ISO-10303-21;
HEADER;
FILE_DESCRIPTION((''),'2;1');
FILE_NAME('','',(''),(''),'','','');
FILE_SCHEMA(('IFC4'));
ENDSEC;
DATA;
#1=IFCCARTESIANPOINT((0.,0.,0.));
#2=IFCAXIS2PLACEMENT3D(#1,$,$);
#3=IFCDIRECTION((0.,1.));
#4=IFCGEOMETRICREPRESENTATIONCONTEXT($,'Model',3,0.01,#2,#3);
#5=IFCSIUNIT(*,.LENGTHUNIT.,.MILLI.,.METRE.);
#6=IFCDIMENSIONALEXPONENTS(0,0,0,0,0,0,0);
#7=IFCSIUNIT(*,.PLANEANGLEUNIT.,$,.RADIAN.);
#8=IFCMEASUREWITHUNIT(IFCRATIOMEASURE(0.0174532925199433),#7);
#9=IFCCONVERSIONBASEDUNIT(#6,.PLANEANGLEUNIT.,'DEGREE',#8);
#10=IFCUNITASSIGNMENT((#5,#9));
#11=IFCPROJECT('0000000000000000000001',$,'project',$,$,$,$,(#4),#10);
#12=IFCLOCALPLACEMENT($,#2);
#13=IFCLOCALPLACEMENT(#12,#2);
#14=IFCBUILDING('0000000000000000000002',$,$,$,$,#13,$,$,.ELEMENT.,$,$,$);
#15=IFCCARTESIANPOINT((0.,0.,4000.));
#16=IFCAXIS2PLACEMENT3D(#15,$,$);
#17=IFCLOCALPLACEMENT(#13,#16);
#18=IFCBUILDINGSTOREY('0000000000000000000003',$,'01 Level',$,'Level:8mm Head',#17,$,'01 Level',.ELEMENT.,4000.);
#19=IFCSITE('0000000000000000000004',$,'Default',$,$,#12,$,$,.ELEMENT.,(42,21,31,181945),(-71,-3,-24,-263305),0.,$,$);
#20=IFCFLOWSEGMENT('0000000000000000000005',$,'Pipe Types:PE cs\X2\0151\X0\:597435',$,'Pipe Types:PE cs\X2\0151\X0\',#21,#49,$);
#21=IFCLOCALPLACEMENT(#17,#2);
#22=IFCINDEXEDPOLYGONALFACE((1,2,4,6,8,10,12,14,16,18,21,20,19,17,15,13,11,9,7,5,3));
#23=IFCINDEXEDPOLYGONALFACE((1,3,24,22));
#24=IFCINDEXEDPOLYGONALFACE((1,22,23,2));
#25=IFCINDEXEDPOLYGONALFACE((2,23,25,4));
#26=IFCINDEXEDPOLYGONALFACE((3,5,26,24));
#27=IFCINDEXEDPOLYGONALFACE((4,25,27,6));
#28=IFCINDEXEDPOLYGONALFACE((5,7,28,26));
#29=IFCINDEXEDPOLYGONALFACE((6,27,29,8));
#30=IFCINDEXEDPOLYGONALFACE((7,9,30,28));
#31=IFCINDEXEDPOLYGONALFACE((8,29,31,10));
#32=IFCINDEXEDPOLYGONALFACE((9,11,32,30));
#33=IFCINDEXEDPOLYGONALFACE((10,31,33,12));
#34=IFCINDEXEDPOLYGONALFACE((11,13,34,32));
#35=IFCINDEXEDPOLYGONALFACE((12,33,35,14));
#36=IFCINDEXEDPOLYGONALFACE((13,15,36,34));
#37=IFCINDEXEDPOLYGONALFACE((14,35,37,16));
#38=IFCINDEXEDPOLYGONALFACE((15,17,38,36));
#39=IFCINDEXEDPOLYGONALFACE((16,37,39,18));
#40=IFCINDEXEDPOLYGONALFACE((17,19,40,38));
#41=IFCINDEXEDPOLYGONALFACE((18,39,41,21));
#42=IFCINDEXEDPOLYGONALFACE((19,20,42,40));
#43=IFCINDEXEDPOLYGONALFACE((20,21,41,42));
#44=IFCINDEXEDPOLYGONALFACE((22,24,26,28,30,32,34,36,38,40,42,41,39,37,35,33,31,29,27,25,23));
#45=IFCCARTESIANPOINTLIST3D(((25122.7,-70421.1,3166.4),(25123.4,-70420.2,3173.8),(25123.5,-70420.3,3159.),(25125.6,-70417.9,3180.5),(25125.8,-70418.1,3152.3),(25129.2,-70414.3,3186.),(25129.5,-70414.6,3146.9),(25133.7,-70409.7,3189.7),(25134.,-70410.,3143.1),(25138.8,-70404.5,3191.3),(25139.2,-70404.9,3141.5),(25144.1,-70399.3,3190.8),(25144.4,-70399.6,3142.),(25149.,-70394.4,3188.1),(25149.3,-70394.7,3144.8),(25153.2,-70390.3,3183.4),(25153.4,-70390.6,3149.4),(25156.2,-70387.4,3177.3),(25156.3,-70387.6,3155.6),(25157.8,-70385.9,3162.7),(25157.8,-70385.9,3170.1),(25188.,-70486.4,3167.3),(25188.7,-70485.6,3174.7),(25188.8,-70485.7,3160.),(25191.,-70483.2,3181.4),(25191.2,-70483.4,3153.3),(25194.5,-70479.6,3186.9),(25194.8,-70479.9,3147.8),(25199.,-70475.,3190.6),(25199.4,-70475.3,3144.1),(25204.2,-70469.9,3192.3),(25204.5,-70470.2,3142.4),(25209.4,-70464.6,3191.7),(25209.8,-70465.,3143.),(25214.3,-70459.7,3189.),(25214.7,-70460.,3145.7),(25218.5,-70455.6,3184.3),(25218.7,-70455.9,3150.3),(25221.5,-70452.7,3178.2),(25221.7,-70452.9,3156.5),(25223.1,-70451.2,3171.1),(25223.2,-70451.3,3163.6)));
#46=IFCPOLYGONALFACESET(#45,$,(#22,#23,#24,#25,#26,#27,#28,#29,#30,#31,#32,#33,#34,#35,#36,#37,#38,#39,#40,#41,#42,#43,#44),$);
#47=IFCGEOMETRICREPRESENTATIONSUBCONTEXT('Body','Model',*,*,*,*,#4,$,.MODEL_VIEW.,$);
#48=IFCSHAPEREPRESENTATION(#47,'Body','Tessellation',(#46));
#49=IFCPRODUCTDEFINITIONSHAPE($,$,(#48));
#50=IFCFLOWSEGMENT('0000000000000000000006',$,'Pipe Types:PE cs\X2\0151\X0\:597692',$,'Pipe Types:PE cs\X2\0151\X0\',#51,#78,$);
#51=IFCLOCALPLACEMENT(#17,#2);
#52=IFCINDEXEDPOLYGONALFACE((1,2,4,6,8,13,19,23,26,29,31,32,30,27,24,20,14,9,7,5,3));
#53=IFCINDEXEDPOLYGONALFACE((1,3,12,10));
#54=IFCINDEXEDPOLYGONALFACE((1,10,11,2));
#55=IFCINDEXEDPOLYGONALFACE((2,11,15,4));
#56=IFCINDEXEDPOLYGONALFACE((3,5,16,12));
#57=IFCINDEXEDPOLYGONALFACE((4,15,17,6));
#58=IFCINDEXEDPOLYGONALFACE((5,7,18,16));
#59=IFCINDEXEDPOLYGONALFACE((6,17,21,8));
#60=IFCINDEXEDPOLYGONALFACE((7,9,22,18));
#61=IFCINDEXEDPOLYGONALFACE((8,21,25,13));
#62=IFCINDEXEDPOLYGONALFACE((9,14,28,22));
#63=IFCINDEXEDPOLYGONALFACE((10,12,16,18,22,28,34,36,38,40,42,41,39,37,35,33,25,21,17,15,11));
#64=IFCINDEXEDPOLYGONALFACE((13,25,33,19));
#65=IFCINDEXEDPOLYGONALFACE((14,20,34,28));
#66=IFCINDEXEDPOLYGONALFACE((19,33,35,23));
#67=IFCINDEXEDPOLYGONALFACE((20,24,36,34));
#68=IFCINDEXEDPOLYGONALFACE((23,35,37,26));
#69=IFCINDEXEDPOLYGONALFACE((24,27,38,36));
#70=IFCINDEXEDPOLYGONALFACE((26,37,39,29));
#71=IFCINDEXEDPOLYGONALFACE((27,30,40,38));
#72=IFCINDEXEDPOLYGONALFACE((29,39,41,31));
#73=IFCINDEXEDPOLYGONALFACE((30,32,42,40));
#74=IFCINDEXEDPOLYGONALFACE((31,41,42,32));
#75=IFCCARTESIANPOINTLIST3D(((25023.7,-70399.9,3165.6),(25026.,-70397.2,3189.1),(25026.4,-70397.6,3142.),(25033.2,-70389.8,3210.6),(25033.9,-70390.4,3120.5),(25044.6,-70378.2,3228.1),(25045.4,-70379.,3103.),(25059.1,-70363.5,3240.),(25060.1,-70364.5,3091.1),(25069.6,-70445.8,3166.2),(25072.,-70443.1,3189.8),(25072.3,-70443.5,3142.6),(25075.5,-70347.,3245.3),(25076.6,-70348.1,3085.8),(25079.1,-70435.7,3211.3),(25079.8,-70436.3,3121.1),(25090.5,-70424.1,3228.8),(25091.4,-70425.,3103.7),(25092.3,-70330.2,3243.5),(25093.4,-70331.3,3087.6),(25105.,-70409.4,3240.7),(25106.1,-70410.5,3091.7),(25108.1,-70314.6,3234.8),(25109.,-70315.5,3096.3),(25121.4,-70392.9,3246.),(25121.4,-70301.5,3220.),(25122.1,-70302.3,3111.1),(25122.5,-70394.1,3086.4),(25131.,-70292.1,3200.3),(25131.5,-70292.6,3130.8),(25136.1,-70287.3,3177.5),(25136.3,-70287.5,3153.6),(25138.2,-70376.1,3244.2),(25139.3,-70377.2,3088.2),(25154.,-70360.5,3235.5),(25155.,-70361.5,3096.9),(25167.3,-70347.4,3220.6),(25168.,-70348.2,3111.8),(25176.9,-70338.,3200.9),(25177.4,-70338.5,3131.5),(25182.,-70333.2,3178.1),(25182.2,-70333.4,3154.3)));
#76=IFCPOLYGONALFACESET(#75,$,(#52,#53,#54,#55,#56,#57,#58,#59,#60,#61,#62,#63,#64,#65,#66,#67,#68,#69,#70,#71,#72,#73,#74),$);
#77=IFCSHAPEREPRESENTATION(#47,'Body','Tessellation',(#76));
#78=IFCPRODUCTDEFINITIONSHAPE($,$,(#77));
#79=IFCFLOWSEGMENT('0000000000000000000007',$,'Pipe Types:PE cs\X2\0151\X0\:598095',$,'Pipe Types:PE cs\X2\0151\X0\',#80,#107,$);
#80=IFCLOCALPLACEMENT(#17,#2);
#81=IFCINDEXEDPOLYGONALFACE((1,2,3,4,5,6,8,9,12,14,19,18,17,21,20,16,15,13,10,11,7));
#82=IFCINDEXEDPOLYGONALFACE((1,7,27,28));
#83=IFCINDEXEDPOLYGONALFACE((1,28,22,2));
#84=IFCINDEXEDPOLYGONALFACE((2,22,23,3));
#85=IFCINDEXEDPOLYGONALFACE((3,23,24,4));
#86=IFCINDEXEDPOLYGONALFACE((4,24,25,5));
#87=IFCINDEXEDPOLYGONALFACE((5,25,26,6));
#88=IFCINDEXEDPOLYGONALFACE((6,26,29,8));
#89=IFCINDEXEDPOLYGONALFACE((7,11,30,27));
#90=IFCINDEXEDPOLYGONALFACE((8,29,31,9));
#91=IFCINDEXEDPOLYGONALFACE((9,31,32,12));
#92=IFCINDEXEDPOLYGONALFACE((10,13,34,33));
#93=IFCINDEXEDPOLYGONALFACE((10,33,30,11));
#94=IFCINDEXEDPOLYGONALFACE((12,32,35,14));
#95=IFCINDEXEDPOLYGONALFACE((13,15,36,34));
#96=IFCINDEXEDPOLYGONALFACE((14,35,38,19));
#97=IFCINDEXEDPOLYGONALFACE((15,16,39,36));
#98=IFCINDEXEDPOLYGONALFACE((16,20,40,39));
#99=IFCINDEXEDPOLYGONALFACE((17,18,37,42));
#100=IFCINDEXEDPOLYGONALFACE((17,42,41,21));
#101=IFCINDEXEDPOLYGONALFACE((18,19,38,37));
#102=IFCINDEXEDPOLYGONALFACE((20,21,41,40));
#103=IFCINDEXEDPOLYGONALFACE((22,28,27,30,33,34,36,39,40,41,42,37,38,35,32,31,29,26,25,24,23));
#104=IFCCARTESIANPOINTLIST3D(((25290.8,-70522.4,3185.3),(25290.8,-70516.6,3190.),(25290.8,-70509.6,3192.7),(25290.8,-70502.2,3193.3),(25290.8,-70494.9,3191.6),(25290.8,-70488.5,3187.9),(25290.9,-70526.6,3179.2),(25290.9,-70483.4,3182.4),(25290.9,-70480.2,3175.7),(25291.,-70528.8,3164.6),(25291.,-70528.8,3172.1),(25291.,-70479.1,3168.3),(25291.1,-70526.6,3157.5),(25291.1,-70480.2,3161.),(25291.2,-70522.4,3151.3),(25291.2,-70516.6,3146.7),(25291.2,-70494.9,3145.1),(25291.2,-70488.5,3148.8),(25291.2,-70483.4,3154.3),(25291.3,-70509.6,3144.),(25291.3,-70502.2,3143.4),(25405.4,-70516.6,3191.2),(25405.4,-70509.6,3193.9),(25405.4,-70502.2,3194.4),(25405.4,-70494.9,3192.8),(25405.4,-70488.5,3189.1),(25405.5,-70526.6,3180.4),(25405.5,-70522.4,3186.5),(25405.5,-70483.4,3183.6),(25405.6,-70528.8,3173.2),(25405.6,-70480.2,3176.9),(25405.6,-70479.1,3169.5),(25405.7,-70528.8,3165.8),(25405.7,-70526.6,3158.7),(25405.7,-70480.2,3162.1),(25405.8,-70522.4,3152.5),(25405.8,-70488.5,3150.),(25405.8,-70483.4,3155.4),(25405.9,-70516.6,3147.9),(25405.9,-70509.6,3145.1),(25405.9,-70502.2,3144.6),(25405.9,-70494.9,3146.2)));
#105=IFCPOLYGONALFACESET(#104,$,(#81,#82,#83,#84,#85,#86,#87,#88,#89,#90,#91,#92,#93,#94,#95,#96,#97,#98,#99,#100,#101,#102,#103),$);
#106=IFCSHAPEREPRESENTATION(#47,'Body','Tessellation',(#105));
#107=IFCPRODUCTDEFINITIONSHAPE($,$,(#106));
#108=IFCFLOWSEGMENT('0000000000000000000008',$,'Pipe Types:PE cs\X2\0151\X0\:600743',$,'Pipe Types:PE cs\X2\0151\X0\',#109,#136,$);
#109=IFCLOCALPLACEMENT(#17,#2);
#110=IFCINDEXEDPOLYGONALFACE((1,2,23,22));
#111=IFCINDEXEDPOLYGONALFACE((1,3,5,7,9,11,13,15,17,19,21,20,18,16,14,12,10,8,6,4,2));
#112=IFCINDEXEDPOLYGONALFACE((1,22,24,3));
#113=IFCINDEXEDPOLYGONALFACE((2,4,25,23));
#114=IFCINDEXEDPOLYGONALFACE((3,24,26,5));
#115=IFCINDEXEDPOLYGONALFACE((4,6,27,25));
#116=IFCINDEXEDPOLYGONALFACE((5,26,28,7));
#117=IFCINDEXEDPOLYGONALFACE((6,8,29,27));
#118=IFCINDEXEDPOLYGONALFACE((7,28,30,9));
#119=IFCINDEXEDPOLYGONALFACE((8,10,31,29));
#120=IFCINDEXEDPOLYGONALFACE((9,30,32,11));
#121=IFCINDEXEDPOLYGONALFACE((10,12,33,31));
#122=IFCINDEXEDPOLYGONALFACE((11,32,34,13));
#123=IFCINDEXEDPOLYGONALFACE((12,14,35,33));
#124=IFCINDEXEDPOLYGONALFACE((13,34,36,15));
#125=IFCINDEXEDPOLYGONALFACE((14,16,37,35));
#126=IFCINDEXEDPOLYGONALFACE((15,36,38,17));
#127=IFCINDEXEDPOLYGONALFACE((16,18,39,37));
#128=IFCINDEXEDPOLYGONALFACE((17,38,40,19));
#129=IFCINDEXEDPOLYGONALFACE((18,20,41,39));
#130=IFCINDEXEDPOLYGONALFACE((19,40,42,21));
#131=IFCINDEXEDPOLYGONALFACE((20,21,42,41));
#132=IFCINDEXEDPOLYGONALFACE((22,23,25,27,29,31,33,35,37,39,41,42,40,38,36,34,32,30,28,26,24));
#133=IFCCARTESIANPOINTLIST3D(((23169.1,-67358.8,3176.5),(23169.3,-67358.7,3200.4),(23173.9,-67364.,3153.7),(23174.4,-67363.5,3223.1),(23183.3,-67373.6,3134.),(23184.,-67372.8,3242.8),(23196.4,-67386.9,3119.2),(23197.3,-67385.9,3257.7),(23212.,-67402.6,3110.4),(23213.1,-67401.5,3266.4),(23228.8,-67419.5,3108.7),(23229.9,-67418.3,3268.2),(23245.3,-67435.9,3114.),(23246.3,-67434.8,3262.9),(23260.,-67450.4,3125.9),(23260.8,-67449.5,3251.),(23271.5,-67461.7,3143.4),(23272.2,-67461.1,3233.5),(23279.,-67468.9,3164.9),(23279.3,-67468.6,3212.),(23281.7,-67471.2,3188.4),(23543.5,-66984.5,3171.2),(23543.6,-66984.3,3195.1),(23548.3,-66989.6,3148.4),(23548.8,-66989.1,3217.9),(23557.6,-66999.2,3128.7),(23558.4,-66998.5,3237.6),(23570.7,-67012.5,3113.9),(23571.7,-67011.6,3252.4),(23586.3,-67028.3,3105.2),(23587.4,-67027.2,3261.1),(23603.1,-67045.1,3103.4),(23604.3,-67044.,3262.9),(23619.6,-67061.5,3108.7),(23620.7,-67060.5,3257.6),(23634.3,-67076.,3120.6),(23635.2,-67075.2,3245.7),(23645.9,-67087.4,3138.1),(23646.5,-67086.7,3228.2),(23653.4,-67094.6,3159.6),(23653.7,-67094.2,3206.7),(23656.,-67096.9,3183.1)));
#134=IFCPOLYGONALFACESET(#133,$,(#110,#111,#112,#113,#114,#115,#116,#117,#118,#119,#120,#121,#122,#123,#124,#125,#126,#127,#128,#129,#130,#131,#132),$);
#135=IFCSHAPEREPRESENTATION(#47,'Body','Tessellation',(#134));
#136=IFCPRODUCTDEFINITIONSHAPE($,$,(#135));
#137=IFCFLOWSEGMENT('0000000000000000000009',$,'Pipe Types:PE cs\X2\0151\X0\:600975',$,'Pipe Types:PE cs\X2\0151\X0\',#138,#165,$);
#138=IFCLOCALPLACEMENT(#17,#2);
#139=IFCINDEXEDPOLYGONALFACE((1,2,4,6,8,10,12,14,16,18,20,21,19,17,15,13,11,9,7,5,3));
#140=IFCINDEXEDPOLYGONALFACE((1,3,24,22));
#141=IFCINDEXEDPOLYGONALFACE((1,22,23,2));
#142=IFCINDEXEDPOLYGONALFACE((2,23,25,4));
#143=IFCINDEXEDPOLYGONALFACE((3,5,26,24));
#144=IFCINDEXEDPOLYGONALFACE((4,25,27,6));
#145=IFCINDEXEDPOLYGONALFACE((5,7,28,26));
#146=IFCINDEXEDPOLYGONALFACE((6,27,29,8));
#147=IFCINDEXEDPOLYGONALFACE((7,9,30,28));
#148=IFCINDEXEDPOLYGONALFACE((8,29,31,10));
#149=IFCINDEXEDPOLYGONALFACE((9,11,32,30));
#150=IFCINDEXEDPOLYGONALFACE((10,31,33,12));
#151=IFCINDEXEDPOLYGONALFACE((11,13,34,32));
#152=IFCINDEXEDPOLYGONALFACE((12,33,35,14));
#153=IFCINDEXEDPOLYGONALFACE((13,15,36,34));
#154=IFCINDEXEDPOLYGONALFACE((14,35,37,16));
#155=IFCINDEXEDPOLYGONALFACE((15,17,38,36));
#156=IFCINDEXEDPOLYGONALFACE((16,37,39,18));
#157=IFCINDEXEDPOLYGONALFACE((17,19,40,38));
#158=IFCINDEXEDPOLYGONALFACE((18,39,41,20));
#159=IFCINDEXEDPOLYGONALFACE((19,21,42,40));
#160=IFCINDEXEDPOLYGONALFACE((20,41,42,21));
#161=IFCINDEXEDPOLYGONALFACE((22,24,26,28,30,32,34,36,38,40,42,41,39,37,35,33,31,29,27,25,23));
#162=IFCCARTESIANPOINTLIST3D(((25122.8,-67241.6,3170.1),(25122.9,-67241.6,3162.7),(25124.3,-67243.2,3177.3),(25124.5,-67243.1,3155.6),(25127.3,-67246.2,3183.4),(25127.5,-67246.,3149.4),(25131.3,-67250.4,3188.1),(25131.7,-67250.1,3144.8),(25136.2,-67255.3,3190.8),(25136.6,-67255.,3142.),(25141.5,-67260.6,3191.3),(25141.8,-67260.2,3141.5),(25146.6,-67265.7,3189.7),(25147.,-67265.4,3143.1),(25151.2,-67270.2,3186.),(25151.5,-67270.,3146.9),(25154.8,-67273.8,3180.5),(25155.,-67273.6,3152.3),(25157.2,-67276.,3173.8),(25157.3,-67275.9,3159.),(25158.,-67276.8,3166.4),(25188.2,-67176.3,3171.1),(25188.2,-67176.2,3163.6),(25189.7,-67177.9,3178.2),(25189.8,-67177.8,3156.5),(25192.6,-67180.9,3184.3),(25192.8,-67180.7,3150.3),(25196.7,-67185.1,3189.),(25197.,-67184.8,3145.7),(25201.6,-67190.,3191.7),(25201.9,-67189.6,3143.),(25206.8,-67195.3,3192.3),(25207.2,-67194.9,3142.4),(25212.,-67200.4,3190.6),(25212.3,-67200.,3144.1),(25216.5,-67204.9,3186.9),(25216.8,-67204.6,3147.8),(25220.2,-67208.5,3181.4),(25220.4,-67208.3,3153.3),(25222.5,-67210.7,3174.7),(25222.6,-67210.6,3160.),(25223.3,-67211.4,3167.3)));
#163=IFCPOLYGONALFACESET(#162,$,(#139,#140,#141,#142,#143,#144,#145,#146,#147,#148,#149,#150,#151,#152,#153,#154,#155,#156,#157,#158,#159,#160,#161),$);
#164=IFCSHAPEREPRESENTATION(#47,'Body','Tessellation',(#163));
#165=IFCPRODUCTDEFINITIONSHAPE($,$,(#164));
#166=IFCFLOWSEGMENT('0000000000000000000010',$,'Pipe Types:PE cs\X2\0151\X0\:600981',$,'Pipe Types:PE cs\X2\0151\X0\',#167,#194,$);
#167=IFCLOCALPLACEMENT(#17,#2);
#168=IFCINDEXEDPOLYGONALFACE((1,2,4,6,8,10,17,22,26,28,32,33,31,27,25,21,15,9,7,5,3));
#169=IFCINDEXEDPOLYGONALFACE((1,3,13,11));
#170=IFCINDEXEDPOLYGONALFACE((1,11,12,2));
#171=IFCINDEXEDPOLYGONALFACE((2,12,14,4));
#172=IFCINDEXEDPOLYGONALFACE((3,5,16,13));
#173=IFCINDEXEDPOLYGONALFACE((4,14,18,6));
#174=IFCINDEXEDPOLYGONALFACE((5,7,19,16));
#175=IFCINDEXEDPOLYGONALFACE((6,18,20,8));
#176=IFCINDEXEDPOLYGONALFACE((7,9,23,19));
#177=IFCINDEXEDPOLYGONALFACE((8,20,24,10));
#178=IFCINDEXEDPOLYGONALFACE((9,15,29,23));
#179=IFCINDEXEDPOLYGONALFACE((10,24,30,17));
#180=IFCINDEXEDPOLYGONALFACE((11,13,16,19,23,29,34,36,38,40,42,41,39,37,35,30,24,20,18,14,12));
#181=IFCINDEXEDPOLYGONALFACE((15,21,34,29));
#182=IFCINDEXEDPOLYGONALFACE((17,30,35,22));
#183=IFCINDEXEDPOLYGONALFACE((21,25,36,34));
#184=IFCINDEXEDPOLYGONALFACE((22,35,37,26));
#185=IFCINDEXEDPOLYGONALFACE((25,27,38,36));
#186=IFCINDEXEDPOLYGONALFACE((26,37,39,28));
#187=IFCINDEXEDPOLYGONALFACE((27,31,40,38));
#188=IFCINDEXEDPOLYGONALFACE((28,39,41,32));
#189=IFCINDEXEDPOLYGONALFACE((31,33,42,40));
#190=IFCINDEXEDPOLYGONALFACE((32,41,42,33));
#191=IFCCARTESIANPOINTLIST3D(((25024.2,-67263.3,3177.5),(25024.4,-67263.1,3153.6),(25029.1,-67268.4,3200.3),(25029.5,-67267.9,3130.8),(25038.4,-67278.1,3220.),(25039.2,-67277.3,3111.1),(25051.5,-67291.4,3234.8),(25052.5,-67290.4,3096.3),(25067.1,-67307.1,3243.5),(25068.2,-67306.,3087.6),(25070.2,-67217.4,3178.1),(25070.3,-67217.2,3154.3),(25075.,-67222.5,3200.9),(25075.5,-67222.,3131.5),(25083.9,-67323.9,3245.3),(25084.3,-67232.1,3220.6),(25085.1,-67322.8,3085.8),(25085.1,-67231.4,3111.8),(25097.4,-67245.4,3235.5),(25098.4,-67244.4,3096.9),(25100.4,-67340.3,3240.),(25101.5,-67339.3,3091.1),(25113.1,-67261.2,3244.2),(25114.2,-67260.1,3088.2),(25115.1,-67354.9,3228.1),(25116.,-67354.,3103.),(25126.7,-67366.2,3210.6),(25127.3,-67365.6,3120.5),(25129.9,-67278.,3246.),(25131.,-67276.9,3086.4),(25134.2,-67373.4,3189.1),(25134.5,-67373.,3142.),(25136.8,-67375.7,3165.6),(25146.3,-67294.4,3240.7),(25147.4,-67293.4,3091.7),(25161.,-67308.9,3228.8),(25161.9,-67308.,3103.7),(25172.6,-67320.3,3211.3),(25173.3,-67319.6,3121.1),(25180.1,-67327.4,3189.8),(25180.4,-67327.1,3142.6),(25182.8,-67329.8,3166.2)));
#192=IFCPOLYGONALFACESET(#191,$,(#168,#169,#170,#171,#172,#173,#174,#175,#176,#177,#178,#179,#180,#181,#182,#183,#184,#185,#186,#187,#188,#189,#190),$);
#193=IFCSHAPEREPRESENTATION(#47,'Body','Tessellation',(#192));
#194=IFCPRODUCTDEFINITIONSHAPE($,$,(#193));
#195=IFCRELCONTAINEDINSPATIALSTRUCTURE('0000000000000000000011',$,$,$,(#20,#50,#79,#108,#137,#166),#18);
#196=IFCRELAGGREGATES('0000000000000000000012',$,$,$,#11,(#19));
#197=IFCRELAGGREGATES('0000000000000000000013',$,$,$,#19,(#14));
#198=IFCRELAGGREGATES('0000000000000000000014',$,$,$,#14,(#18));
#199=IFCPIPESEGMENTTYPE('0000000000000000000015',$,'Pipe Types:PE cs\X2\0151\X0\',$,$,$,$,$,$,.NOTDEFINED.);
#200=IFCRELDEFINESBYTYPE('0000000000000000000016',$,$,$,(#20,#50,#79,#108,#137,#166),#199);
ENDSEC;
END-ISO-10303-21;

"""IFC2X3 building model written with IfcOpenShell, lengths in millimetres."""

from ifc_helpers import new_model, entity, si_unit, converted_unit, direction, frame, origin, origin_2d_with_axis, place, context, subcontext, project, spatial, circle, extrude, type_object, element, save


model = new_model("IFC2X3")

# Units and contexts
model_context = context("Model", 3, precision=0.01, world=origin(), true_north=direction((0.0, 1.0)))
body_context = subcontext(model_context, "Body", "Model", "MODEL_VIEW")
ifc_project = project(units=[si_unit("LENGTHUNIT", "METRE", prefix="MILLI"), converted_unit("PLANEANGLEUNIT", "DEGREE", entity("IfcRatioMeasure", 0.0174532925199433), si_unit("PLANEANGLEUNIT", "RADIAN"), dimensions=[0, 0, 0, 0, 0, 0, 0])], contexts=[model_context])

# Site, building, storey
site_placement = place(None, origin())
site = spatial("IfcSite", under=ifc_project, at=site_placement, Name="Default", CompositionType="ELEMENT", RefLatitude=(42, 21, 31, 181945), RefLongitude=(-71, -3, -24, -263305), RefElevation=0.0)
building_placement = place(site_placement, origin())
building = spatial("IfcBuilding", under=site, at=building_placement, CompositionType="ELEMENT")
storey_placement = place(building_placement, frame((0.0, 0.0, 4000.0)))
storey = spatial("IfcBuildingStorey", under=building, at=storey_placement, Name="01 Level", ObjectType="Level:8mm Head", LongName="01 Level", CompositionType="ELEMENT", Elevation=4000.0)

# Flow segments
pipe_segment_type = type_object("IfcPipeSegmentType", Name="Pipe Types:PE cső", PredefinedType="NOTDEFINED")
flow_segment_1_placement = place(storey_placement, frame((25121.1, -70488.0, 3139.8)))
element("IfcFlowSegment", 1, at=flow_segment_1_placement, inside=storey, type_object=pipe_segment_type, Name="Pipe Types:PE cső:597435", ObjectType="Pipe Types:PE cső", context=body_context, shape_type="SweptSolid", body=[
    extrude(circle(Radius=25.0, at=origin_2d_with_axis()), frame((19.3, 84.6, 26.6), z_axis=(0.707072, -0.707071, 0.009982), x_axis=(-0.707107, -0.707107, 0.0)), (0.0, 0.0, 1.0), 92.4),
])
flow_segment_2_placement = place(storey_placement, frame((25022.1, -70447.4, 3084.0)))
element("IfcFlowSegment", 2, at=flow_segment_2_placement, inside=storey, type_object=pipe_segment_type, Name="Pipe Types:PE cső:597692", ObjectType="Pipe Types:PE cső", context=body_context, shape_type="SweptSolid", body=[
    extrude(circle(Radius=80.0, at=origin_2d_with_axis()), frame((58.2, 104.1, 81.6), z_axis=(0.707071, -0.707071, 0.010046), x_axis=(-0.707107, -0.707107, 0.0)), (0.0, 0.0, 1.0), 65.0),
])
flow_segment_3_placement = place(storey_placement, frame((25289.2, -70530.7, 3141.7)))
element("IfcFlowSegment", 3, at=flow_segment_3_placement, inside=storey, type_object=pipe_segment_type, Name="Pipe Types:PE cső:598095", ObjectType="Pipe Types:PE cső", context=body_context, shape_type="SweptSolid", body=[
    extrude(circle(Radius=25.0, at=origin_2d_with_axis()), frame((1.9, 26.6, 26.6), z_axis=(0.999948, -0.000032, 0.010203), x_axis=(0.000032, 1.0, 0.0)), (0.0, 0.0, 1.0), 114.6),
])
flow_segment_4_placement = place(storey_placement, frame((23167.0, -67472.8, 3101.6)))
element("IfcFlowSegment", 4, at=flow_segment_4_placement, inside=storey, type_object=pipe_segment_type, Name="Pipe Types:PE cső:600743", ObjectType="Pipe Types:PE cső", context=body_context, shape_type="SweptSolid", body=[
    extrude(circle(Radius=80.0, at=origin_2d_with_axis()), frame((58.2, 58.2, 86.9), z_axis=(0.707071, 0.707071, -0.01), x_axis=(0.707107, -0.707107, 0.0)), (0.0, 0.0, 1.0), 529.4),
])
flow_segment_5_placement = place(storey_placement, frame((25121.1, -67278.4, 3139.8)))
element("IfcFlowSegment", 5, at=flow_segment_5_placement, inside=storey, type_object=pipe_segment_type, Name="Pipe Types:PE cső:600975", ObjectType="Pipe Types:PE cső", context=body_context, shape_type="SweptSolid", body=[
    extrude(circle(Radius=25.0, at=origin_2d_with_axis()), frame((19.3, 19.3, 26.6), z_axis=(0.707072, 0.707071, 0.009982), x_axis=(0.707107, -0.707107, 0.0)), (0.0, 0.0, 1.0), 92.4),
])
flow_segment_6_placement = place(storey_placement, frame((25022.1, -67377.3, 3084.0)))
element("IfcFlowSegment", 6, at=flow_segment_6_placement, inside=storey, type_object=pipe_segment_type, Name="Pipe Types:PE cső:600981", ObjectType="Pipe Types:PE cső", context=body_context, shape_type="SweptSolid", body=[
    extrude(circle(Radius=80.0, at=origin_2d_with_axis()), frame((58.2, 58.2, 81.6), z_axis=(0.707071, 0.707071, 0.010046), x_axis=(0.707107, -0.707107, 0.0)), (0.0, 0.0, 1.0), 65.0),
])

save(model, "model.ifc")
